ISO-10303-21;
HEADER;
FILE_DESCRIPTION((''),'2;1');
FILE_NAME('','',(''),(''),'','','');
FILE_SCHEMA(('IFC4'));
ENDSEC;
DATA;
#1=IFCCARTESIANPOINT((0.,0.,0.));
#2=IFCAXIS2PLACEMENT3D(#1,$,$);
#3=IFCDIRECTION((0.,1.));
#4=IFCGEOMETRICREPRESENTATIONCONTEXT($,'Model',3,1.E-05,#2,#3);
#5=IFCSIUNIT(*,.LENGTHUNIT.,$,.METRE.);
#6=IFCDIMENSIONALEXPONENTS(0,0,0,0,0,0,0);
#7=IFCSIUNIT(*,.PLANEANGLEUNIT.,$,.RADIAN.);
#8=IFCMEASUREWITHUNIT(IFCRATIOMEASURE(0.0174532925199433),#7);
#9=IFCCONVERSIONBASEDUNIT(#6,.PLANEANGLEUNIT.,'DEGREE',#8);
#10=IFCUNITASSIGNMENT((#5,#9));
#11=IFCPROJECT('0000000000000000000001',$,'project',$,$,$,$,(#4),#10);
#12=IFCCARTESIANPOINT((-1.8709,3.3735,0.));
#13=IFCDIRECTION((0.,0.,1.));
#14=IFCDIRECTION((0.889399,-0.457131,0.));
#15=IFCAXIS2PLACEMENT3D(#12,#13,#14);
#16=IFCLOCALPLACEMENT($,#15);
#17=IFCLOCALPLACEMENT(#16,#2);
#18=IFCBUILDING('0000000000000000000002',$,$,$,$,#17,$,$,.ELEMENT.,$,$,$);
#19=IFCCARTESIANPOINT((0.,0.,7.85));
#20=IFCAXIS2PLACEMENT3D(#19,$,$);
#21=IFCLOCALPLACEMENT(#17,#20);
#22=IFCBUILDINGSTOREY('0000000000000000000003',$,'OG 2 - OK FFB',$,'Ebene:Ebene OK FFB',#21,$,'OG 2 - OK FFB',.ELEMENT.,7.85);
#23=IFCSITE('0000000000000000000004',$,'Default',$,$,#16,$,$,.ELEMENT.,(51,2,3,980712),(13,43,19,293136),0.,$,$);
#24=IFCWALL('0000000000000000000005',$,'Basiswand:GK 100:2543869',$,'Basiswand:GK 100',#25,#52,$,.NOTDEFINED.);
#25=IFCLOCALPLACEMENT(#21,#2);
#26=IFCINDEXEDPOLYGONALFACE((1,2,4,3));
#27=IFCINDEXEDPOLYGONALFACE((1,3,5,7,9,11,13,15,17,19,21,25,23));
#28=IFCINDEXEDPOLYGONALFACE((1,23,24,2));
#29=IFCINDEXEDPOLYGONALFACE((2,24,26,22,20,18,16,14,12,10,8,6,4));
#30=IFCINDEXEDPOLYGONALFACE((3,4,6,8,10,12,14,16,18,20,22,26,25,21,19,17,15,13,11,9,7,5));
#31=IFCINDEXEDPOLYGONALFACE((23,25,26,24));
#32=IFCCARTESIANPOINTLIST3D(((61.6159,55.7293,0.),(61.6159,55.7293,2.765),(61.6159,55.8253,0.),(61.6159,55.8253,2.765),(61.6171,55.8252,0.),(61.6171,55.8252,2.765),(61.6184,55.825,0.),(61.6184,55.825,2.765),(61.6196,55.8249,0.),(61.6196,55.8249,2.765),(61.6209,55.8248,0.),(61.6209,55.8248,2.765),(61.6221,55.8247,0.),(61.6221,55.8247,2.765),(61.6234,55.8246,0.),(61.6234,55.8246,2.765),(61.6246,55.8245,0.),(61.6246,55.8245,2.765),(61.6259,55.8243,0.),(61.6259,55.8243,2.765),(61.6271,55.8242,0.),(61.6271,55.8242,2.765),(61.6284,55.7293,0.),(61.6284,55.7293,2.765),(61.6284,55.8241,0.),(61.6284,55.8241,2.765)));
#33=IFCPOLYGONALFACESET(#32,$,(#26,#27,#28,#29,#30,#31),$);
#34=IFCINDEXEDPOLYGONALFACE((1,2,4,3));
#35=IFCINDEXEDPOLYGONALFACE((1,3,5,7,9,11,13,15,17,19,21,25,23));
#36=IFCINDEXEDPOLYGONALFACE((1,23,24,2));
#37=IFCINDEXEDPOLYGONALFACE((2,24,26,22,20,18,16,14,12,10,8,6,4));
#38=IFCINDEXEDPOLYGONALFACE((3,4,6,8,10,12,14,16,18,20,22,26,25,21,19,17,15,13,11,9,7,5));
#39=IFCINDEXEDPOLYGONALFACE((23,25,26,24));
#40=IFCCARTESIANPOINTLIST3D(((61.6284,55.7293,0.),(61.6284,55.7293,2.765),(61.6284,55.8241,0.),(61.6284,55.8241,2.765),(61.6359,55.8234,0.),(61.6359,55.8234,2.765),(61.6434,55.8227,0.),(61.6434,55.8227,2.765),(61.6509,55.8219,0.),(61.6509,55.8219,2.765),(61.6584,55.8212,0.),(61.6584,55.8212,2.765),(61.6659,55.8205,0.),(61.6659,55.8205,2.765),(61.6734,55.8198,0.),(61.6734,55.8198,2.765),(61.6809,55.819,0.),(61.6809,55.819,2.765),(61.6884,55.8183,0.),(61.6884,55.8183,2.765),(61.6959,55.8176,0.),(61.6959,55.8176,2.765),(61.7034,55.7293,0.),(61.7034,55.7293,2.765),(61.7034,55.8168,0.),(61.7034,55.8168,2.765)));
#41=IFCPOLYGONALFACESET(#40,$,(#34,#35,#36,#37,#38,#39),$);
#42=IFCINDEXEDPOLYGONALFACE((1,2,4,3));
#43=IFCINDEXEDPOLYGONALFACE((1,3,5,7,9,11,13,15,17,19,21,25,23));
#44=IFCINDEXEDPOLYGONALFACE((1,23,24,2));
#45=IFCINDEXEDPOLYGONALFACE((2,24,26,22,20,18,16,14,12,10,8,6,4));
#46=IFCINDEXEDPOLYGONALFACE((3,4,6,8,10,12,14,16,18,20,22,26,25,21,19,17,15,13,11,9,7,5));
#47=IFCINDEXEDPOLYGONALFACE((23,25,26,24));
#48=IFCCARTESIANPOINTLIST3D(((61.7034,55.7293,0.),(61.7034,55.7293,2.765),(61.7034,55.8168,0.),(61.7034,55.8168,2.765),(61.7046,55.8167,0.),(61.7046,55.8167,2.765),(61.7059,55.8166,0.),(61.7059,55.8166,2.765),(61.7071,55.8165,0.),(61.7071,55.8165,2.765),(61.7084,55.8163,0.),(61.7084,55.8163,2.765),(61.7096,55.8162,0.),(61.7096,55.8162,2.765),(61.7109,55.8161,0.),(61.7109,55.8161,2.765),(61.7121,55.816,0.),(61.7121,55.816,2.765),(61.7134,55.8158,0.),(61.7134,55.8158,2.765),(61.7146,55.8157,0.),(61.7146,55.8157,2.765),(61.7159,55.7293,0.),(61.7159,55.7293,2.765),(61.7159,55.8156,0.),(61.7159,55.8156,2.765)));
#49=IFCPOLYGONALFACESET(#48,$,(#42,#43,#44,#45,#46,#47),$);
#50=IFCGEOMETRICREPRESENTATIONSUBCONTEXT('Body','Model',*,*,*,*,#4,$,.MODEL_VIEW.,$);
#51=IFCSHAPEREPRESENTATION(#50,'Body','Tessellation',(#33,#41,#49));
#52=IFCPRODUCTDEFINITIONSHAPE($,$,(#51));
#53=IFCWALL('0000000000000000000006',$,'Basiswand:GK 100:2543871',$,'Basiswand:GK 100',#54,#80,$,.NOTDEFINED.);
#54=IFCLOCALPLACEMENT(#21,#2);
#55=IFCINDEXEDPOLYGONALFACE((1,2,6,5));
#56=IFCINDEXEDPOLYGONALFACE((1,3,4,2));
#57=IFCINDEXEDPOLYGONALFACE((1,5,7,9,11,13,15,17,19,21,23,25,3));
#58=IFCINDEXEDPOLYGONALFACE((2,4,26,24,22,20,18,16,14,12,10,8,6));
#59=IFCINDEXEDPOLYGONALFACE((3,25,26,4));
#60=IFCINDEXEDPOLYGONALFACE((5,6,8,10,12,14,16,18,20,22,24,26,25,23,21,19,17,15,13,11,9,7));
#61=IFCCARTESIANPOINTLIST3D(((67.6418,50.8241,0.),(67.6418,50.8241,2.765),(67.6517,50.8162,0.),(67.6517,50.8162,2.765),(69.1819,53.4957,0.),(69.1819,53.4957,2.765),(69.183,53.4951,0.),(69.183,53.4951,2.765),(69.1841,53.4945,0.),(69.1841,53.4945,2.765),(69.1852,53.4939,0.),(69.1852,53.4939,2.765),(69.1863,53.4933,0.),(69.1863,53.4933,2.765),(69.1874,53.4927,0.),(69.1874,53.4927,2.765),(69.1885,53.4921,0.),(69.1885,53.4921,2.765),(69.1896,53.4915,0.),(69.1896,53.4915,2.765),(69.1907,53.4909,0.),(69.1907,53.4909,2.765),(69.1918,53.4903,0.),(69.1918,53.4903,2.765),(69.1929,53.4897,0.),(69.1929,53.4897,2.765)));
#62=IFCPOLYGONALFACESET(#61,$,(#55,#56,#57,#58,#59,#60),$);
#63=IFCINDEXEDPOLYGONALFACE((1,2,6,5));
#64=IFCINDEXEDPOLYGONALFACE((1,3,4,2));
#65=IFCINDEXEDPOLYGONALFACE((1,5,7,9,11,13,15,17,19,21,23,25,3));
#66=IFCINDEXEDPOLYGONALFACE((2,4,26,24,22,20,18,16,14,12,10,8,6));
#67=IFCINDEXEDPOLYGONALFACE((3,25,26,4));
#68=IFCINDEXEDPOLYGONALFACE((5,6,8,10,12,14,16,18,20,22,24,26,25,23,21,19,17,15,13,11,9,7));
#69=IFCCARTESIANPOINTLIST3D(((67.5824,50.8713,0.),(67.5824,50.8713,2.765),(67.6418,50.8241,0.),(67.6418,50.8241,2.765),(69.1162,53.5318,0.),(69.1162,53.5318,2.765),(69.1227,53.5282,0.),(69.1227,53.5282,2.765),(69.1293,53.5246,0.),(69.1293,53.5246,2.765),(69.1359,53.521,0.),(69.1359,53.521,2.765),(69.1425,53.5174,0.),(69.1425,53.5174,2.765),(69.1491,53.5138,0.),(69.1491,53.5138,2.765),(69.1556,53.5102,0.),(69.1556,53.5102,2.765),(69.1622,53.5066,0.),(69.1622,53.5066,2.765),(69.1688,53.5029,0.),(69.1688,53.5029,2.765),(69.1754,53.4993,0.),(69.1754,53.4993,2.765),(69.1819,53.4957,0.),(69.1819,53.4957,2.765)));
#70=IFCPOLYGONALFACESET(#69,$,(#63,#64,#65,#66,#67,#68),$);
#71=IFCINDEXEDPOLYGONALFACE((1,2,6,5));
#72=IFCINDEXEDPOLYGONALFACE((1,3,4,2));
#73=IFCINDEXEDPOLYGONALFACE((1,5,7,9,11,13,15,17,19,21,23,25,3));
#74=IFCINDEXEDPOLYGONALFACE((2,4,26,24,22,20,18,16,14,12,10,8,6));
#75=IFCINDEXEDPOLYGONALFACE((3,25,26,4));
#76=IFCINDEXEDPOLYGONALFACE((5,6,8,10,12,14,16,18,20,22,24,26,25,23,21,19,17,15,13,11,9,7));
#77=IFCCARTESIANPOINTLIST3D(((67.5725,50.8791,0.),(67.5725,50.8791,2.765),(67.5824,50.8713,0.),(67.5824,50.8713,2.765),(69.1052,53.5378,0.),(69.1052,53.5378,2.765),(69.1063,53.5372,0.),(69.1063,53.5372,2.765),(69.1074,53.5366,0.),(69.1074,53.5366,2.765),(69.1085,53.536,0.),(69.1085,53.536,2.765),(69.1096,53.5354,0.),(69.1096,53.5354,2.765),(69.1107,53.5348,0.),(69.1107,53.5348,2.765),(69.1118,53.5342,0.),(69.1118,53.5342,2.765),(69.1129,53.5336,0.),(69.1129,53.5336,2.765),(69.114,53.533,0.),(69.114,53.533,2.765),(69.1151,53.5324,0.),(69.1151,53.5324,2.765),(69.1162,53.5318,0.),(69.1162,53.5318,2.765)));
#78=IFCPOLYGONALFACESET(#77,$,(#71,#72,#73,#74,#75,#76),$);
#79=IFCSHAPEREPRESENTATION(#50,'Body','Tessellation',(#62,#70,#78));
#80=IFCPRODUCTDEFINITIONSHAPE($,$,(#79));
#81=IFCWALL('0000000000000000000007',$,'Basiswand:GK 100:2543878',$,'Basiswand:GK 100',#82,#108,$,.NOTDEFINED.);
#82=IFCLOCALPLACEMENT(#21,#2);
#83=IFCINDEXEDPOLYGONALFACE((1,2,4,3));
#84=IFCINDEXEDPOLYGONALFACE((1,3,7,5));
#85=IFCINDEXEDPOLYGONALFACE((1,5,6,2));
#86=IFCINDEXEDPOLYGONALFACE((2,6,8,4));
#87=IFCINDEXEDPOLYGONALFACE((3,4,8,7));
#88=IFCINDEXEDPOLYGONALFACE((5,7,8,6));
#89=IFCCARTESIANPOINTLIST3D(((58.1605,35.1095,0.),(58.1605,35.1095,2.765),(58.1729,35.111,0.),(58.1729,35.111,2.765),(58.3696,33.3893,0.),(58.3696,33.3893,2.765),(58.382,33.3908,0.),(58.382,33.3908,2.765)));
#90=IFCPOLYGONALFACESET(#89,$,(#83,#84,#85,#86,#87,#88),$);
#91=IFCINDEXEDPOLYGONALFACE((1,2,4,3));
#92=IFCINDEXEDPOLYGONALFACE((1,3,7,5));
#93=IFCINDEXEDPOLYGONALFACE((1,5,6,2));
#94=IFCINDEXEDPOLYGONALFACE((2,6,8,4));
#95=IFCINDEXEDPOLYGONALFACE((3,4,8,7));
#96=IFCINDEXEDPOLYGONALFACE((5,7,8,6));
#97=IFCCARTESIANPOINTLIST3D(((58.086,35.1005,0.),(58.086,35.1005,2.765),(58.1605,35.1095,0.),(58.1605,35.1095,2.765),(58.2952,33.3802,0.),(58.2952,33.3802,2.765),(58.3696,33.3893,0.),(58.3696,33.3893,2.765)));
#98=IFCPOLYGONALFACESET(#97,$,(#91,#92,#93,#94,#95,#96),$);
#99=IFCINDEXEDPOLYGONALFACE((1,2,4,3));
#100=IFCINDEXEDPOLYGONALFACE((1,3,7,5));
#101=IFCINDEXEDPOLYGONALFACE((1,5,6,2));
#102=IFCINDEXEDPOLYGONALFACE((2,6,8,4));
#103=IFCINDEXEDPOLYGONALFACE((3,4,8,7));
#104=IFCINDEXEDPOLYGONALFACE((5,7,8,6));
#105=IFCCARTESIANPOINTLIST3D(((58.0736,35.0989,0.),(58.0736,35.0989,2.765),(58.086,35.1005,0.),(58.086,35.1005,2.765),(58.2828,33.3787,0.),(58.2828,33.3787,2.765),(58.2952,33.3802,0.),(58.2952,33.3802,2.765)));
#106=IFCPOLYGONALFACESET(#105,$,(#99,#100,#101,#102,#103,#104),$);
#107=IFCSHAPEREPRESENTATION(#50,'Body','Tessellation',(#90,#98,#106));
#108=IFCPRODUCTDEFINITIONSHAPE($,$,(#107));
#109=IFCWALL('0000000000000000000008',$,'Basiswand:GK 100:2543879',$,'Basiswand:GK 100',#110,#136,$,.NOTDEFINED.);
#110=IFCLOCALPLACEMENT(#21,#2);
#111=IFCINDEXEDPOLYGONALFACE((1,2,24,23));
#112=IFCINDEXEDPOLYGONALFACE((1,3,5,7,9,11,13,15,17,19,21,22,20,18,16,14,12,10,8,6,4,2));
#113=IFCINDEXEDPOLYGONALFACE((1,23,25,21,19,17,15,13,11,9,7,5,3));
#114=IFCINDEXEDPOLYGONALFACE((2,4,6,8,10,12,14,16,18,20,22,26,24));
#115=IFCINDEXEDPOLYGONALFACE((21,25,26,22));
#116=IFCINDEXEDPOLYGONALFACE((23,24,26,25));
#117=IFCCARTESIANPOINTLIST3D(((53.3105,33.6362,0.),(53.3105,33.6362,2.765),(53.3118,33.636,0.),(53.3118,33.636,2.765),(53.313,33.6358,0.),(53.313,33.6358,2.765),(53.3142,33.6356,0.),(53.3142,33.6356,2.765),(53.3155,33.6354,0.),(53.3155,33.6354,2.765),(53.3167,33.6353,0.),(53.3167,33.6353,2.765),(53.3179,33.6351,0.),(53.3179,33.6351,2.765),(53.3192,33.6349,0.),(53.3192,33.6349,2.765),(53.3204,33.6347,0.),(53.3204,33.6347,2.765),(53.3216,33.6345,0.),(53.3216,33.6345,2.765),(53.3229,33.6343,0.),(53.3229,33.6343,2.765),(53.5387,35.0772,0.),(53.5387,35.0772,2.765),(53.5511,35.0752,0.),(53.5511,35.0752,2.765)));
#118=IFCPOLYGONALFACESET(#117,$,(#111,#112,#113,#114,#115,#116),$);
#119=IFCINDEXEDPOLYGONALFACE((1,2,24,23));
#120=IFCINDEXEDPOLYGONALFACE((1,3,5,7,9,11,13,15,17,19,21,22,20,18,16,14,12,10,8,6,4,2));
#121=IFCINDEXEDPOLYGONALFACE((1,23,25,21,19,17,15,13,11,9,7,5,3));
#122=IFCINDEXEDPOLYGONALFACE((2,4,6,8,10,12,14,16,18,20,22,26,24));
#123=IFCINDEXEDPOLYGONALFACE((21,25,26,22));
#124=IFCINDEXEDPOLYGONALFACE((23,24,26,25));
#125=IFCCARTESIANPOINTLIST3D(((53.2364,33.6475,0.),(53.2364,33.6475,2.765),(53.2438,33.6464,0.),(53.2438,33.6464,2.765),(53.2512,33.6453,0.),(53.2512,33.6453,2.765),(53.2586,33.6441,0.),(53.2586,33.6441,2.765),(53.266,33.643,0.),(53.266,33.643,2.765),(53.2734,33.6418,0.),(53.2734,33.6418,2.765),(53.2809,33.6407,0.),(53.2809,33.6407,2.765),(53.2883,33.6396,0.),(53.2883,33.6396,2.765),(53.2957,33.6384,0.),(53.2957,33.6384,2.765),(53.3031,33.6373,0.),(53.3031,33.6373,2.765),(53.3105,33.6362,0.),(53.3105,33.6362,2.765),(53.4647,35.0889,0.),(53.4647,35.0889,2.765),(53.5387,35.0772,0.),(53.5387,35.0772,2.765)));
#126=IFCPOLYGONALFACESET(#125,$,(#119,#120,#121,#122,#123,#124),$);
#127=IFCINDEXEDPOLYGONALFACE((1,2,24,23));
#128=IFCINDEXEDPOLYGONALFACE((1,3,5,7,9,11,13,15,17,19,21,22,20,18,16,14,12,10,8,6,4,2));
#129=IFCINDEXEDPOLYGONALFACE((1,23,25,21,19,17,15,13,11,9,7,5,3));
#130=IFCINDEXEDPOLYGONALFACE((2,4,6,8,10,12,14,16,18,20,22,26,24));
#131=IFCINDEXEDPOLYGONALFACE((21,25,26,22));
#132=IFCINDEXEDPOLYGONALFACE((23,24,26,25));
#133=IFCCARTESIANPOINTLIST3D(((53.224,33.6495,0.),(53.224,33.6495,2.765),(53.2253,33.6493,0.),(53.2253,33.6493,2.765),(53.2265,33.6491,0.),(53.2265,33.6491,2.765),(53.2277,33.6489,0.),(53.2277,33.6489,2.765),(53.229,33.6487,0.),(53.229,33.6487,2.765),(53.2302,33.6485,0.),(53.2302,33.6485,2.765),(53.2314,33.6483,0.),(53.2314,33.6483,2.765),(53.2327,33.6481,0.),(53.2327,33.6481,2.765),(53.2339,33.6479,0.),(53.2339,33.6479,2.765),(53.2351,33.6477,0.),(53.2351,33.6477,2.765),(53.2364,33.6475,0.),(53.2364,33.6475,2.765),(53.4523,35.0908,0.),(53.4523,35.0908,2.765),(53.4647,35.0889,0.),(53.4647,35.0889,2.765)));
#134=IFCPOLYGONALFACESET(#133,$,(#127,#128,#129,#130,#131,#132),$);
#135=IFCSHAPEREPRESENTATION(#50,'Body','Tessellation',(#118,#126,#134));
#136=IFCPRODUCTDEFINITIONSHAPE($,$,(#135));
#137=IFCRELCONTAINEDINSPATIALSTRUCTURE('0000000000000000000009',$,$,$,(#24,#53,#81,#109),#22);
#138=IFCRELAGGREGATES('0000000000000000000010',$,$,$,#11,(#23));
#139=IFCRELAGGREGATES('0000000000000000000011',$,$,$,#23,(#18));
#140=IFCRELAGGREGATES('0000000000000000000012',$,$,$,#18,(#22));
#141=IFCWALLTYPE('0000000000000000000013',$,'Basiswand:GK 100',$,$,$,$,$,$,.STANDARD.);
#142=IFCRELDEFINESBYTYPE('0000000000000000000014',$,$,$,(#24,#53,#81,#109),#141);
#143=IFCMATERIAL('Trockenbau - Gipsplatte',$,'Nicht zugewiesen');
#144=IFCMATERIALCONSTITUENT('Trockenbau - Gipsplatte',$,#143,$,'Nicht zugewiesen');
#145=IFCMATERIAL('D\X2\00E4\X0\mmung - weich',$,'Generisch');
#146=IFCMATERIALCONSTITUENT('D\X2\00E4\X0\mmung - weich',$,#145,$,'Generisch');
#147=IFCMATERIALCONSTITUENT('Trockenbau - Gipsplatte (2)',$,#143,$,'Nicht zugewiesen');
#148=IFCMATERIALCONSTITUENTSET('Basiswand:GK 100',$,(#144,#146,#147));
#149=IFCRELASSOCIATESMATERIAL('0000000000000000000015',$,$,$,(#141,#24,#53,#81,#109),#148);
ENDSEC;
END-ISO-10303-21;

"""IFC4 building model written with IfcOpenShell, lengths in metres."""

from ifc_helpers import new_model, entity, si_unit, converted_unit, direction, frame, origin, place, context, subcontext, project, spatial, indexed_curve, outline, extrude, material, constituent, constituent_set, type_object, element, save


model = new_model("IFC4")

# Units and contexts
model_context = context("Model", 3, precision=1e-05, world=origin(), true_north=direction((0.0, 1.0)))
body_context = subcontext(model_context, "Body", "Model", "MODEL_VIEW")
ifc_project = project(units=[si_unit("LENGTHUNIT", "METRE"), converted_unit("PLANEANGLEUNIT", "DEGREE", entity("IfcRatioMeasure", 0.0174532925199433), si_unit("PLANEANGLEUNIT", "RADIAN"), dimensions=[0, 0, 0, 0, 0, 0, 0])], contexts=[model_context])

# Site, building, storey
site_placement = place(None, frame((-1.8709, 3.3735, 0.0), z_axis=(0.0, 0.0, 1.0), x_axis=(0.889399, -0.457131, 0.0)))
site = spatial("IfcSite", under=ifc_project, at=site_placement, Name="Default", CompositionType="ELEMENT", RefLatitude=(51, 2, 3, 980712), RefLongitude=(13, 43, 19, 293136), RefElevation=0.0)
building_placement = place(site_placement, origin())
building = spatial("IfcBuilding", under=site, at=building_placement, CompositionType="ELEMENT")
storey_placement = place(building_placement, frame((0.0, 0.0, 7.85)))
storey = spatial("IfcBuildingStorey", under=building, at=storey_placement, Name="OG 2 - OK FFB", ObjectType="Ebene:Ebene OK FFB", LongName="OG 2 - OK FFB", CompositionType="ELEMENT", Elevation=7.85)

# Walls
ifc_material_1 = material(Name="Trockenbau - Gipsplatte", Category="Nicht zugewiesen")
ifc_constituent_1 = constituent(ifc_material_1, Name="Trockenbau - Gipsplatte", Category="Nicht zugewiesen")
ifc_material_2 = material(Name="Dämmung - weich", Category="Generisch")
ifc_constituent_2 = constituent(ifc_material_2, Name="Dämmung - weich", Category="Generisch")
ifc_constituent_3 = constituent(ifc_material_1, Name="Trockenbau - Gipsplatte (2)", Category="Nicht zugewiesen")
ifc_constituent_set_1 = constituent_set(constituents=[ifc_constituent_1, ifc_constituent_2, ifc_constituent_3], Name="Basiswand:GK 100")
wall_type_1 = type_object("IfcWallType", Name="Basiswand:GK 100", PredefinedType="STANDARD", material=ifc_constituent_set_1)
wall_1_placement = place(storey_placement, frame((61.6659, 55.8253, 0.0), z_axis=(0.0, 0.0, 1.0), x_axis=(0.0, -1.0, 0.0)))
element("IfcWall", 1, at=wall_1_placement, inside=storey, type_object=wall_type_1, material=ifc_constituent_set_1, Name="Basiswand:GK 100:2543869", ObjectType="Basiswand:GK 100", PredefinedType="NOTDEFINED", context=body_context, shape_type="SweptSolid", body=[
    extrude(outline(indexed_curve([(-0.0063, -0.0477), (0.0062, -0.0477), (0.0062, 0.0471), (0.005, 0.0472), (0.0038, 0.0473), (0.0025, 0.0474), (0.0013, 0.0476), (0.0, 0.0477), (-0.0012, 0.0478), (-0.0025, 0.0479), (-0.0037, 0.048), (-0.005, 0.0481), (-0.0063, 0.0483), (-0.0063, -0.0477)], self_intersect=False)), frame((0.0483, -0.0437, 0.0), z_axis=(0.0, 0.0, 1.0), x_axis=(0.0, 1.0, 0.0)), (0.0, 0.0, 1.0), 2.765),
    extrude(outline(indexed_curve([(-0.0492, -0.0375), (0.0456, -0.0375), (0.0456, 0.0375), (-0.0419, 0.0375), (-0.0427, 0.03), (-0.0434, 0.0225), (-0.0441, 0.015), (-0.0449, 0.0075), (-0.0456, 0.0), (-0.0463, -0.0075), (-0.047, -0.015), (-0.0478, -0.0225), (-0.0485, -0.03), (-0.0492, -0.0375)], self_intersect=False)), frame((0.0504, 0.0, 0.0)), (0.0, 0.0, 1.0), 2.765),
    extrude(outline(indexed_curve([(-0.002, -0.0432), (-0.0007, -0.0432), (0.0005, -0.0432), (0.0018, -0.0432), (0.003, -0.0432), (0.0043, -0.0432), (0.0055, -0.0432), (0.0068, -0.0432), (0.0081, -0.0432), (0.0093, -0.0432), (0.0106, -0.0432), (0.0019, 0.0438), (-0.0105, 0.0426), (-0.002, -0.0432)], self_intersect=False)), frame((0.0525, 0.0438, 0.0), z_axis=(0.0, 0.0, 1.0), x_axis=(-0.098754, -0.995112, 0.0)), (0.0, 0.0, 1.0), 2.765),
])
wall_2_placement = place(storey_placement, frame((67.6084, 50.8412, 0.0), z_axis=(0.0, 0.0, 1.0), x_axis=(0.49944, 0.866348, 0.0)))
element("IfcWall", 2, at=wall_2_placement, inside=storey, type_object=wall_type_1, material=ifc_constituent_set_1, Name="Basiswand:GK 100:2543871", ObjectType="Basiswand:GK 100", PredefinedType="NOTDEFINED", context=body_context, shape_type="SweptSolid", body=[
    extrude(outline(indexed_curve([(-0.0361, -1.5421), (-0.0348, -1.5421), (-0.0336, -1.5421), (-0.0323, -1.5421), (-0.0311, -1.5421), (-0.0298, -1.5421), (-0.0286, -1.5421), (-0.0273, -1.5421), (-0.0261, -1.5421), (-0.0248, -1.5421), (-0.0236, -1.5421), (0.0361, 1.5411), (0.0236, 1.5432), (-0.0361, -1.5421)], self_intersect=False)), frame((1.5434, -0.0438, 0.0), z_axis=(0.0, 0.0, 1.0), x_axis=(-0.019339, 0.999813, 0.0)), (0.0, 0.0, 1.0), 2.765),
    extrude(outline(indexed_curve([(-1.5443, -0.0375), (1.5395, -0.0375), (1.5393, -0.03), (1.5392, -0.0225), (1.539, -0.015), (1.5389, -0.0075), (1.5387, 0.0), (1.5385, 0.0075), (1.5384, 0.015), (1.5382, 0.0225), (1.538, 0.03), (1.5379, 0.0375), (-1.5331, 0.0375), (-1.5443, -0.0375)], self_intersect=False)), frame((1.5462, 0.0, 0.0)), (0.0, 0.0, 1.0), 2.765),
    extrude(outline(indexed_curve([(0.221, -1.518), (0.2337, -1.518), (-0.2212, 1.5191), (-0.2224, 1.5188), (-0.2236, 1.5186), (-0.2249, 1.5184), (-0.2261, 1.5182), (-0.2273, 1.518), (-0.2286, 1.5178), (-0.2298, 1.5176), (-0.231, 1.5173), (-0.2323, 1.5171), (-0.2335, 1.5169), (0.221, -1.518)], self_intersect=False)), frame((1.549, 0.0437, 0.0), z_axis=(0.0, 0.0, 1.0), x_axis=(-0.148113, -0.98897, 0.0)), (0.0, 0.0, 1.0), 2.765),
])
wall_3_placement = place(storey_placement, frame((58.3324, 33.3847, 0.0), z_axis=(0.0, 0.0, 1.0), x_axis=(-0.120705, 0.992688, 0.0)))
element("IfcWall", 3, at=wall_3_placement, inside=storey, type_object=wall_type_1, material=ifc_constituent_set_1, Name="Basiswand:GK 100:2543878", ObjectType="Basiswand:GK 100", PredefinedType="NOTDEFINED", context=body_context, shape_type="SweptSolid", body=[
    extrude(outline(indexed_curve([(-0.0062, -0.8665), (0.0063, -0.8665), (0.0062, 0.8665), (-0.0063, 0.8665), (-0.0062, -0.8665)], self_intersect=False)), frame((0.8665, -0.0437, 0.0), z_axis=(0.0, 0.0, 1.0), x_axis=(0.0, 1.0, 0.0)), (0.0, 0.0, 1.0), 2.765),
    extrude(outline(indexed_curve([(-0.8665, -0.0375), (0.8665, -0.0375), (0.8665, 0.0375), (-0.8665, 0.0375), (-0.8665, -0.0375)], self_intersect=False)), frame((0.8665, 0.0, 0.0)), (0.0, 0.0, 1.0), 2.765),
    extrude(outline(indexed_curve([(-0.0063, -0.8665), (0.0062, -0.8665), (0.0063, 0.8665), (-0.0062, 0.8665), (-0.0063, -0.8665)], self_intersect=False)), frame((0.8665, 0.0437, 0.0), z_axis=(0.0, 0.0, 1.0), x_axis=(0.0, -1.0, 0.0)), (0.0, 0.0, 1.0), 2.765),
])
wall_4_placement = place(storey_placement, frame((53.2734, 33.6416, 0.0), z_axis=(0.0, 0.0, 1.0), x_axis=(0.156434, 0.987688, 0.0)))
element("IfcWall", 4, at=wall_4_placement, inside=storey, type_object=wall_type_1, material=ifc_constituent_set_1, Name="Basiswand:GK 100:2543879", ObjectType="Basiswand:GK 100", PredefinedType="NOTDEFINED", context=body_context, shape_type="SweptSolid", body=[
    extrude(outline(indexed_curve([(-0.0063, -0.7294), (0.0062, -0.7294), (0.0063, 0.7295), (0.005, 0.7295), (0.0037, 0.7295), (0.0025, 0.7295), (0.0012, 0.7295), (0.0, 0.7294), (-0.0013, 0.7294), (-0.0025, 0.7294), (-0.0038, 0.7294), (-0.005, 0.7294), (-0.0062, 0.7294), (-0.0063, -0.7294)], self_intersect=False)), frame((0.7299, -0.0437, 0.0), z_axis=(0.0, 0.0, 1.0), x_axis=(0.0, 1.0, 0.0)), (0.0, 0.0, 1.0), 2.765),
    extrude(outline(indexed_curve([(-0.7294, -0.0375), (0.7296, -0.0375), (0.7296, 0.0375), (-0.7297, 0.0375), (-0.7297, 0.03), (-0.7297, 0.0225), (-0.7297, 0.015), (-0.7296, 0.0075), (-0.7296, 0.0), (-0.7296, -0.0075), (-0.7295, -0.015), (-0.7295, -0.0225), (-0.7294, -0.03), (-0.7294, -0.0375)], self_intersect=False)), frame((0.7298, 0.0, 0.0)), (0.0, 0.0, 1.0), 2.765),
    extrude(outline(indexed_curve([(-0.0081, -0.7297), (-0.0069, -0.7297), (-0.0056, -0.7297), (-0.0044, -0.7297), (-0.0031, -0.7297), (-0.0019, -0.7297), (-0.0006, -0.7297), (0.0006, -0.7297), (0.0019, -0.7297), (0.0031, -0.7297), (0.0044, -0.7297), (0.0081, 0.7296), (-0.0044, 0.7297), (-0.0081, -0.7297)], self_intersect=False)), frame((0.7297, 0.0438, 0.0), z_axis=(0.0, 0.0, 1.0), x_axis=(0.002568, -0.999997, 0.0)), (0.0, 0.0, 1.0), 2.765),
])

save(model, "model.ifc")
